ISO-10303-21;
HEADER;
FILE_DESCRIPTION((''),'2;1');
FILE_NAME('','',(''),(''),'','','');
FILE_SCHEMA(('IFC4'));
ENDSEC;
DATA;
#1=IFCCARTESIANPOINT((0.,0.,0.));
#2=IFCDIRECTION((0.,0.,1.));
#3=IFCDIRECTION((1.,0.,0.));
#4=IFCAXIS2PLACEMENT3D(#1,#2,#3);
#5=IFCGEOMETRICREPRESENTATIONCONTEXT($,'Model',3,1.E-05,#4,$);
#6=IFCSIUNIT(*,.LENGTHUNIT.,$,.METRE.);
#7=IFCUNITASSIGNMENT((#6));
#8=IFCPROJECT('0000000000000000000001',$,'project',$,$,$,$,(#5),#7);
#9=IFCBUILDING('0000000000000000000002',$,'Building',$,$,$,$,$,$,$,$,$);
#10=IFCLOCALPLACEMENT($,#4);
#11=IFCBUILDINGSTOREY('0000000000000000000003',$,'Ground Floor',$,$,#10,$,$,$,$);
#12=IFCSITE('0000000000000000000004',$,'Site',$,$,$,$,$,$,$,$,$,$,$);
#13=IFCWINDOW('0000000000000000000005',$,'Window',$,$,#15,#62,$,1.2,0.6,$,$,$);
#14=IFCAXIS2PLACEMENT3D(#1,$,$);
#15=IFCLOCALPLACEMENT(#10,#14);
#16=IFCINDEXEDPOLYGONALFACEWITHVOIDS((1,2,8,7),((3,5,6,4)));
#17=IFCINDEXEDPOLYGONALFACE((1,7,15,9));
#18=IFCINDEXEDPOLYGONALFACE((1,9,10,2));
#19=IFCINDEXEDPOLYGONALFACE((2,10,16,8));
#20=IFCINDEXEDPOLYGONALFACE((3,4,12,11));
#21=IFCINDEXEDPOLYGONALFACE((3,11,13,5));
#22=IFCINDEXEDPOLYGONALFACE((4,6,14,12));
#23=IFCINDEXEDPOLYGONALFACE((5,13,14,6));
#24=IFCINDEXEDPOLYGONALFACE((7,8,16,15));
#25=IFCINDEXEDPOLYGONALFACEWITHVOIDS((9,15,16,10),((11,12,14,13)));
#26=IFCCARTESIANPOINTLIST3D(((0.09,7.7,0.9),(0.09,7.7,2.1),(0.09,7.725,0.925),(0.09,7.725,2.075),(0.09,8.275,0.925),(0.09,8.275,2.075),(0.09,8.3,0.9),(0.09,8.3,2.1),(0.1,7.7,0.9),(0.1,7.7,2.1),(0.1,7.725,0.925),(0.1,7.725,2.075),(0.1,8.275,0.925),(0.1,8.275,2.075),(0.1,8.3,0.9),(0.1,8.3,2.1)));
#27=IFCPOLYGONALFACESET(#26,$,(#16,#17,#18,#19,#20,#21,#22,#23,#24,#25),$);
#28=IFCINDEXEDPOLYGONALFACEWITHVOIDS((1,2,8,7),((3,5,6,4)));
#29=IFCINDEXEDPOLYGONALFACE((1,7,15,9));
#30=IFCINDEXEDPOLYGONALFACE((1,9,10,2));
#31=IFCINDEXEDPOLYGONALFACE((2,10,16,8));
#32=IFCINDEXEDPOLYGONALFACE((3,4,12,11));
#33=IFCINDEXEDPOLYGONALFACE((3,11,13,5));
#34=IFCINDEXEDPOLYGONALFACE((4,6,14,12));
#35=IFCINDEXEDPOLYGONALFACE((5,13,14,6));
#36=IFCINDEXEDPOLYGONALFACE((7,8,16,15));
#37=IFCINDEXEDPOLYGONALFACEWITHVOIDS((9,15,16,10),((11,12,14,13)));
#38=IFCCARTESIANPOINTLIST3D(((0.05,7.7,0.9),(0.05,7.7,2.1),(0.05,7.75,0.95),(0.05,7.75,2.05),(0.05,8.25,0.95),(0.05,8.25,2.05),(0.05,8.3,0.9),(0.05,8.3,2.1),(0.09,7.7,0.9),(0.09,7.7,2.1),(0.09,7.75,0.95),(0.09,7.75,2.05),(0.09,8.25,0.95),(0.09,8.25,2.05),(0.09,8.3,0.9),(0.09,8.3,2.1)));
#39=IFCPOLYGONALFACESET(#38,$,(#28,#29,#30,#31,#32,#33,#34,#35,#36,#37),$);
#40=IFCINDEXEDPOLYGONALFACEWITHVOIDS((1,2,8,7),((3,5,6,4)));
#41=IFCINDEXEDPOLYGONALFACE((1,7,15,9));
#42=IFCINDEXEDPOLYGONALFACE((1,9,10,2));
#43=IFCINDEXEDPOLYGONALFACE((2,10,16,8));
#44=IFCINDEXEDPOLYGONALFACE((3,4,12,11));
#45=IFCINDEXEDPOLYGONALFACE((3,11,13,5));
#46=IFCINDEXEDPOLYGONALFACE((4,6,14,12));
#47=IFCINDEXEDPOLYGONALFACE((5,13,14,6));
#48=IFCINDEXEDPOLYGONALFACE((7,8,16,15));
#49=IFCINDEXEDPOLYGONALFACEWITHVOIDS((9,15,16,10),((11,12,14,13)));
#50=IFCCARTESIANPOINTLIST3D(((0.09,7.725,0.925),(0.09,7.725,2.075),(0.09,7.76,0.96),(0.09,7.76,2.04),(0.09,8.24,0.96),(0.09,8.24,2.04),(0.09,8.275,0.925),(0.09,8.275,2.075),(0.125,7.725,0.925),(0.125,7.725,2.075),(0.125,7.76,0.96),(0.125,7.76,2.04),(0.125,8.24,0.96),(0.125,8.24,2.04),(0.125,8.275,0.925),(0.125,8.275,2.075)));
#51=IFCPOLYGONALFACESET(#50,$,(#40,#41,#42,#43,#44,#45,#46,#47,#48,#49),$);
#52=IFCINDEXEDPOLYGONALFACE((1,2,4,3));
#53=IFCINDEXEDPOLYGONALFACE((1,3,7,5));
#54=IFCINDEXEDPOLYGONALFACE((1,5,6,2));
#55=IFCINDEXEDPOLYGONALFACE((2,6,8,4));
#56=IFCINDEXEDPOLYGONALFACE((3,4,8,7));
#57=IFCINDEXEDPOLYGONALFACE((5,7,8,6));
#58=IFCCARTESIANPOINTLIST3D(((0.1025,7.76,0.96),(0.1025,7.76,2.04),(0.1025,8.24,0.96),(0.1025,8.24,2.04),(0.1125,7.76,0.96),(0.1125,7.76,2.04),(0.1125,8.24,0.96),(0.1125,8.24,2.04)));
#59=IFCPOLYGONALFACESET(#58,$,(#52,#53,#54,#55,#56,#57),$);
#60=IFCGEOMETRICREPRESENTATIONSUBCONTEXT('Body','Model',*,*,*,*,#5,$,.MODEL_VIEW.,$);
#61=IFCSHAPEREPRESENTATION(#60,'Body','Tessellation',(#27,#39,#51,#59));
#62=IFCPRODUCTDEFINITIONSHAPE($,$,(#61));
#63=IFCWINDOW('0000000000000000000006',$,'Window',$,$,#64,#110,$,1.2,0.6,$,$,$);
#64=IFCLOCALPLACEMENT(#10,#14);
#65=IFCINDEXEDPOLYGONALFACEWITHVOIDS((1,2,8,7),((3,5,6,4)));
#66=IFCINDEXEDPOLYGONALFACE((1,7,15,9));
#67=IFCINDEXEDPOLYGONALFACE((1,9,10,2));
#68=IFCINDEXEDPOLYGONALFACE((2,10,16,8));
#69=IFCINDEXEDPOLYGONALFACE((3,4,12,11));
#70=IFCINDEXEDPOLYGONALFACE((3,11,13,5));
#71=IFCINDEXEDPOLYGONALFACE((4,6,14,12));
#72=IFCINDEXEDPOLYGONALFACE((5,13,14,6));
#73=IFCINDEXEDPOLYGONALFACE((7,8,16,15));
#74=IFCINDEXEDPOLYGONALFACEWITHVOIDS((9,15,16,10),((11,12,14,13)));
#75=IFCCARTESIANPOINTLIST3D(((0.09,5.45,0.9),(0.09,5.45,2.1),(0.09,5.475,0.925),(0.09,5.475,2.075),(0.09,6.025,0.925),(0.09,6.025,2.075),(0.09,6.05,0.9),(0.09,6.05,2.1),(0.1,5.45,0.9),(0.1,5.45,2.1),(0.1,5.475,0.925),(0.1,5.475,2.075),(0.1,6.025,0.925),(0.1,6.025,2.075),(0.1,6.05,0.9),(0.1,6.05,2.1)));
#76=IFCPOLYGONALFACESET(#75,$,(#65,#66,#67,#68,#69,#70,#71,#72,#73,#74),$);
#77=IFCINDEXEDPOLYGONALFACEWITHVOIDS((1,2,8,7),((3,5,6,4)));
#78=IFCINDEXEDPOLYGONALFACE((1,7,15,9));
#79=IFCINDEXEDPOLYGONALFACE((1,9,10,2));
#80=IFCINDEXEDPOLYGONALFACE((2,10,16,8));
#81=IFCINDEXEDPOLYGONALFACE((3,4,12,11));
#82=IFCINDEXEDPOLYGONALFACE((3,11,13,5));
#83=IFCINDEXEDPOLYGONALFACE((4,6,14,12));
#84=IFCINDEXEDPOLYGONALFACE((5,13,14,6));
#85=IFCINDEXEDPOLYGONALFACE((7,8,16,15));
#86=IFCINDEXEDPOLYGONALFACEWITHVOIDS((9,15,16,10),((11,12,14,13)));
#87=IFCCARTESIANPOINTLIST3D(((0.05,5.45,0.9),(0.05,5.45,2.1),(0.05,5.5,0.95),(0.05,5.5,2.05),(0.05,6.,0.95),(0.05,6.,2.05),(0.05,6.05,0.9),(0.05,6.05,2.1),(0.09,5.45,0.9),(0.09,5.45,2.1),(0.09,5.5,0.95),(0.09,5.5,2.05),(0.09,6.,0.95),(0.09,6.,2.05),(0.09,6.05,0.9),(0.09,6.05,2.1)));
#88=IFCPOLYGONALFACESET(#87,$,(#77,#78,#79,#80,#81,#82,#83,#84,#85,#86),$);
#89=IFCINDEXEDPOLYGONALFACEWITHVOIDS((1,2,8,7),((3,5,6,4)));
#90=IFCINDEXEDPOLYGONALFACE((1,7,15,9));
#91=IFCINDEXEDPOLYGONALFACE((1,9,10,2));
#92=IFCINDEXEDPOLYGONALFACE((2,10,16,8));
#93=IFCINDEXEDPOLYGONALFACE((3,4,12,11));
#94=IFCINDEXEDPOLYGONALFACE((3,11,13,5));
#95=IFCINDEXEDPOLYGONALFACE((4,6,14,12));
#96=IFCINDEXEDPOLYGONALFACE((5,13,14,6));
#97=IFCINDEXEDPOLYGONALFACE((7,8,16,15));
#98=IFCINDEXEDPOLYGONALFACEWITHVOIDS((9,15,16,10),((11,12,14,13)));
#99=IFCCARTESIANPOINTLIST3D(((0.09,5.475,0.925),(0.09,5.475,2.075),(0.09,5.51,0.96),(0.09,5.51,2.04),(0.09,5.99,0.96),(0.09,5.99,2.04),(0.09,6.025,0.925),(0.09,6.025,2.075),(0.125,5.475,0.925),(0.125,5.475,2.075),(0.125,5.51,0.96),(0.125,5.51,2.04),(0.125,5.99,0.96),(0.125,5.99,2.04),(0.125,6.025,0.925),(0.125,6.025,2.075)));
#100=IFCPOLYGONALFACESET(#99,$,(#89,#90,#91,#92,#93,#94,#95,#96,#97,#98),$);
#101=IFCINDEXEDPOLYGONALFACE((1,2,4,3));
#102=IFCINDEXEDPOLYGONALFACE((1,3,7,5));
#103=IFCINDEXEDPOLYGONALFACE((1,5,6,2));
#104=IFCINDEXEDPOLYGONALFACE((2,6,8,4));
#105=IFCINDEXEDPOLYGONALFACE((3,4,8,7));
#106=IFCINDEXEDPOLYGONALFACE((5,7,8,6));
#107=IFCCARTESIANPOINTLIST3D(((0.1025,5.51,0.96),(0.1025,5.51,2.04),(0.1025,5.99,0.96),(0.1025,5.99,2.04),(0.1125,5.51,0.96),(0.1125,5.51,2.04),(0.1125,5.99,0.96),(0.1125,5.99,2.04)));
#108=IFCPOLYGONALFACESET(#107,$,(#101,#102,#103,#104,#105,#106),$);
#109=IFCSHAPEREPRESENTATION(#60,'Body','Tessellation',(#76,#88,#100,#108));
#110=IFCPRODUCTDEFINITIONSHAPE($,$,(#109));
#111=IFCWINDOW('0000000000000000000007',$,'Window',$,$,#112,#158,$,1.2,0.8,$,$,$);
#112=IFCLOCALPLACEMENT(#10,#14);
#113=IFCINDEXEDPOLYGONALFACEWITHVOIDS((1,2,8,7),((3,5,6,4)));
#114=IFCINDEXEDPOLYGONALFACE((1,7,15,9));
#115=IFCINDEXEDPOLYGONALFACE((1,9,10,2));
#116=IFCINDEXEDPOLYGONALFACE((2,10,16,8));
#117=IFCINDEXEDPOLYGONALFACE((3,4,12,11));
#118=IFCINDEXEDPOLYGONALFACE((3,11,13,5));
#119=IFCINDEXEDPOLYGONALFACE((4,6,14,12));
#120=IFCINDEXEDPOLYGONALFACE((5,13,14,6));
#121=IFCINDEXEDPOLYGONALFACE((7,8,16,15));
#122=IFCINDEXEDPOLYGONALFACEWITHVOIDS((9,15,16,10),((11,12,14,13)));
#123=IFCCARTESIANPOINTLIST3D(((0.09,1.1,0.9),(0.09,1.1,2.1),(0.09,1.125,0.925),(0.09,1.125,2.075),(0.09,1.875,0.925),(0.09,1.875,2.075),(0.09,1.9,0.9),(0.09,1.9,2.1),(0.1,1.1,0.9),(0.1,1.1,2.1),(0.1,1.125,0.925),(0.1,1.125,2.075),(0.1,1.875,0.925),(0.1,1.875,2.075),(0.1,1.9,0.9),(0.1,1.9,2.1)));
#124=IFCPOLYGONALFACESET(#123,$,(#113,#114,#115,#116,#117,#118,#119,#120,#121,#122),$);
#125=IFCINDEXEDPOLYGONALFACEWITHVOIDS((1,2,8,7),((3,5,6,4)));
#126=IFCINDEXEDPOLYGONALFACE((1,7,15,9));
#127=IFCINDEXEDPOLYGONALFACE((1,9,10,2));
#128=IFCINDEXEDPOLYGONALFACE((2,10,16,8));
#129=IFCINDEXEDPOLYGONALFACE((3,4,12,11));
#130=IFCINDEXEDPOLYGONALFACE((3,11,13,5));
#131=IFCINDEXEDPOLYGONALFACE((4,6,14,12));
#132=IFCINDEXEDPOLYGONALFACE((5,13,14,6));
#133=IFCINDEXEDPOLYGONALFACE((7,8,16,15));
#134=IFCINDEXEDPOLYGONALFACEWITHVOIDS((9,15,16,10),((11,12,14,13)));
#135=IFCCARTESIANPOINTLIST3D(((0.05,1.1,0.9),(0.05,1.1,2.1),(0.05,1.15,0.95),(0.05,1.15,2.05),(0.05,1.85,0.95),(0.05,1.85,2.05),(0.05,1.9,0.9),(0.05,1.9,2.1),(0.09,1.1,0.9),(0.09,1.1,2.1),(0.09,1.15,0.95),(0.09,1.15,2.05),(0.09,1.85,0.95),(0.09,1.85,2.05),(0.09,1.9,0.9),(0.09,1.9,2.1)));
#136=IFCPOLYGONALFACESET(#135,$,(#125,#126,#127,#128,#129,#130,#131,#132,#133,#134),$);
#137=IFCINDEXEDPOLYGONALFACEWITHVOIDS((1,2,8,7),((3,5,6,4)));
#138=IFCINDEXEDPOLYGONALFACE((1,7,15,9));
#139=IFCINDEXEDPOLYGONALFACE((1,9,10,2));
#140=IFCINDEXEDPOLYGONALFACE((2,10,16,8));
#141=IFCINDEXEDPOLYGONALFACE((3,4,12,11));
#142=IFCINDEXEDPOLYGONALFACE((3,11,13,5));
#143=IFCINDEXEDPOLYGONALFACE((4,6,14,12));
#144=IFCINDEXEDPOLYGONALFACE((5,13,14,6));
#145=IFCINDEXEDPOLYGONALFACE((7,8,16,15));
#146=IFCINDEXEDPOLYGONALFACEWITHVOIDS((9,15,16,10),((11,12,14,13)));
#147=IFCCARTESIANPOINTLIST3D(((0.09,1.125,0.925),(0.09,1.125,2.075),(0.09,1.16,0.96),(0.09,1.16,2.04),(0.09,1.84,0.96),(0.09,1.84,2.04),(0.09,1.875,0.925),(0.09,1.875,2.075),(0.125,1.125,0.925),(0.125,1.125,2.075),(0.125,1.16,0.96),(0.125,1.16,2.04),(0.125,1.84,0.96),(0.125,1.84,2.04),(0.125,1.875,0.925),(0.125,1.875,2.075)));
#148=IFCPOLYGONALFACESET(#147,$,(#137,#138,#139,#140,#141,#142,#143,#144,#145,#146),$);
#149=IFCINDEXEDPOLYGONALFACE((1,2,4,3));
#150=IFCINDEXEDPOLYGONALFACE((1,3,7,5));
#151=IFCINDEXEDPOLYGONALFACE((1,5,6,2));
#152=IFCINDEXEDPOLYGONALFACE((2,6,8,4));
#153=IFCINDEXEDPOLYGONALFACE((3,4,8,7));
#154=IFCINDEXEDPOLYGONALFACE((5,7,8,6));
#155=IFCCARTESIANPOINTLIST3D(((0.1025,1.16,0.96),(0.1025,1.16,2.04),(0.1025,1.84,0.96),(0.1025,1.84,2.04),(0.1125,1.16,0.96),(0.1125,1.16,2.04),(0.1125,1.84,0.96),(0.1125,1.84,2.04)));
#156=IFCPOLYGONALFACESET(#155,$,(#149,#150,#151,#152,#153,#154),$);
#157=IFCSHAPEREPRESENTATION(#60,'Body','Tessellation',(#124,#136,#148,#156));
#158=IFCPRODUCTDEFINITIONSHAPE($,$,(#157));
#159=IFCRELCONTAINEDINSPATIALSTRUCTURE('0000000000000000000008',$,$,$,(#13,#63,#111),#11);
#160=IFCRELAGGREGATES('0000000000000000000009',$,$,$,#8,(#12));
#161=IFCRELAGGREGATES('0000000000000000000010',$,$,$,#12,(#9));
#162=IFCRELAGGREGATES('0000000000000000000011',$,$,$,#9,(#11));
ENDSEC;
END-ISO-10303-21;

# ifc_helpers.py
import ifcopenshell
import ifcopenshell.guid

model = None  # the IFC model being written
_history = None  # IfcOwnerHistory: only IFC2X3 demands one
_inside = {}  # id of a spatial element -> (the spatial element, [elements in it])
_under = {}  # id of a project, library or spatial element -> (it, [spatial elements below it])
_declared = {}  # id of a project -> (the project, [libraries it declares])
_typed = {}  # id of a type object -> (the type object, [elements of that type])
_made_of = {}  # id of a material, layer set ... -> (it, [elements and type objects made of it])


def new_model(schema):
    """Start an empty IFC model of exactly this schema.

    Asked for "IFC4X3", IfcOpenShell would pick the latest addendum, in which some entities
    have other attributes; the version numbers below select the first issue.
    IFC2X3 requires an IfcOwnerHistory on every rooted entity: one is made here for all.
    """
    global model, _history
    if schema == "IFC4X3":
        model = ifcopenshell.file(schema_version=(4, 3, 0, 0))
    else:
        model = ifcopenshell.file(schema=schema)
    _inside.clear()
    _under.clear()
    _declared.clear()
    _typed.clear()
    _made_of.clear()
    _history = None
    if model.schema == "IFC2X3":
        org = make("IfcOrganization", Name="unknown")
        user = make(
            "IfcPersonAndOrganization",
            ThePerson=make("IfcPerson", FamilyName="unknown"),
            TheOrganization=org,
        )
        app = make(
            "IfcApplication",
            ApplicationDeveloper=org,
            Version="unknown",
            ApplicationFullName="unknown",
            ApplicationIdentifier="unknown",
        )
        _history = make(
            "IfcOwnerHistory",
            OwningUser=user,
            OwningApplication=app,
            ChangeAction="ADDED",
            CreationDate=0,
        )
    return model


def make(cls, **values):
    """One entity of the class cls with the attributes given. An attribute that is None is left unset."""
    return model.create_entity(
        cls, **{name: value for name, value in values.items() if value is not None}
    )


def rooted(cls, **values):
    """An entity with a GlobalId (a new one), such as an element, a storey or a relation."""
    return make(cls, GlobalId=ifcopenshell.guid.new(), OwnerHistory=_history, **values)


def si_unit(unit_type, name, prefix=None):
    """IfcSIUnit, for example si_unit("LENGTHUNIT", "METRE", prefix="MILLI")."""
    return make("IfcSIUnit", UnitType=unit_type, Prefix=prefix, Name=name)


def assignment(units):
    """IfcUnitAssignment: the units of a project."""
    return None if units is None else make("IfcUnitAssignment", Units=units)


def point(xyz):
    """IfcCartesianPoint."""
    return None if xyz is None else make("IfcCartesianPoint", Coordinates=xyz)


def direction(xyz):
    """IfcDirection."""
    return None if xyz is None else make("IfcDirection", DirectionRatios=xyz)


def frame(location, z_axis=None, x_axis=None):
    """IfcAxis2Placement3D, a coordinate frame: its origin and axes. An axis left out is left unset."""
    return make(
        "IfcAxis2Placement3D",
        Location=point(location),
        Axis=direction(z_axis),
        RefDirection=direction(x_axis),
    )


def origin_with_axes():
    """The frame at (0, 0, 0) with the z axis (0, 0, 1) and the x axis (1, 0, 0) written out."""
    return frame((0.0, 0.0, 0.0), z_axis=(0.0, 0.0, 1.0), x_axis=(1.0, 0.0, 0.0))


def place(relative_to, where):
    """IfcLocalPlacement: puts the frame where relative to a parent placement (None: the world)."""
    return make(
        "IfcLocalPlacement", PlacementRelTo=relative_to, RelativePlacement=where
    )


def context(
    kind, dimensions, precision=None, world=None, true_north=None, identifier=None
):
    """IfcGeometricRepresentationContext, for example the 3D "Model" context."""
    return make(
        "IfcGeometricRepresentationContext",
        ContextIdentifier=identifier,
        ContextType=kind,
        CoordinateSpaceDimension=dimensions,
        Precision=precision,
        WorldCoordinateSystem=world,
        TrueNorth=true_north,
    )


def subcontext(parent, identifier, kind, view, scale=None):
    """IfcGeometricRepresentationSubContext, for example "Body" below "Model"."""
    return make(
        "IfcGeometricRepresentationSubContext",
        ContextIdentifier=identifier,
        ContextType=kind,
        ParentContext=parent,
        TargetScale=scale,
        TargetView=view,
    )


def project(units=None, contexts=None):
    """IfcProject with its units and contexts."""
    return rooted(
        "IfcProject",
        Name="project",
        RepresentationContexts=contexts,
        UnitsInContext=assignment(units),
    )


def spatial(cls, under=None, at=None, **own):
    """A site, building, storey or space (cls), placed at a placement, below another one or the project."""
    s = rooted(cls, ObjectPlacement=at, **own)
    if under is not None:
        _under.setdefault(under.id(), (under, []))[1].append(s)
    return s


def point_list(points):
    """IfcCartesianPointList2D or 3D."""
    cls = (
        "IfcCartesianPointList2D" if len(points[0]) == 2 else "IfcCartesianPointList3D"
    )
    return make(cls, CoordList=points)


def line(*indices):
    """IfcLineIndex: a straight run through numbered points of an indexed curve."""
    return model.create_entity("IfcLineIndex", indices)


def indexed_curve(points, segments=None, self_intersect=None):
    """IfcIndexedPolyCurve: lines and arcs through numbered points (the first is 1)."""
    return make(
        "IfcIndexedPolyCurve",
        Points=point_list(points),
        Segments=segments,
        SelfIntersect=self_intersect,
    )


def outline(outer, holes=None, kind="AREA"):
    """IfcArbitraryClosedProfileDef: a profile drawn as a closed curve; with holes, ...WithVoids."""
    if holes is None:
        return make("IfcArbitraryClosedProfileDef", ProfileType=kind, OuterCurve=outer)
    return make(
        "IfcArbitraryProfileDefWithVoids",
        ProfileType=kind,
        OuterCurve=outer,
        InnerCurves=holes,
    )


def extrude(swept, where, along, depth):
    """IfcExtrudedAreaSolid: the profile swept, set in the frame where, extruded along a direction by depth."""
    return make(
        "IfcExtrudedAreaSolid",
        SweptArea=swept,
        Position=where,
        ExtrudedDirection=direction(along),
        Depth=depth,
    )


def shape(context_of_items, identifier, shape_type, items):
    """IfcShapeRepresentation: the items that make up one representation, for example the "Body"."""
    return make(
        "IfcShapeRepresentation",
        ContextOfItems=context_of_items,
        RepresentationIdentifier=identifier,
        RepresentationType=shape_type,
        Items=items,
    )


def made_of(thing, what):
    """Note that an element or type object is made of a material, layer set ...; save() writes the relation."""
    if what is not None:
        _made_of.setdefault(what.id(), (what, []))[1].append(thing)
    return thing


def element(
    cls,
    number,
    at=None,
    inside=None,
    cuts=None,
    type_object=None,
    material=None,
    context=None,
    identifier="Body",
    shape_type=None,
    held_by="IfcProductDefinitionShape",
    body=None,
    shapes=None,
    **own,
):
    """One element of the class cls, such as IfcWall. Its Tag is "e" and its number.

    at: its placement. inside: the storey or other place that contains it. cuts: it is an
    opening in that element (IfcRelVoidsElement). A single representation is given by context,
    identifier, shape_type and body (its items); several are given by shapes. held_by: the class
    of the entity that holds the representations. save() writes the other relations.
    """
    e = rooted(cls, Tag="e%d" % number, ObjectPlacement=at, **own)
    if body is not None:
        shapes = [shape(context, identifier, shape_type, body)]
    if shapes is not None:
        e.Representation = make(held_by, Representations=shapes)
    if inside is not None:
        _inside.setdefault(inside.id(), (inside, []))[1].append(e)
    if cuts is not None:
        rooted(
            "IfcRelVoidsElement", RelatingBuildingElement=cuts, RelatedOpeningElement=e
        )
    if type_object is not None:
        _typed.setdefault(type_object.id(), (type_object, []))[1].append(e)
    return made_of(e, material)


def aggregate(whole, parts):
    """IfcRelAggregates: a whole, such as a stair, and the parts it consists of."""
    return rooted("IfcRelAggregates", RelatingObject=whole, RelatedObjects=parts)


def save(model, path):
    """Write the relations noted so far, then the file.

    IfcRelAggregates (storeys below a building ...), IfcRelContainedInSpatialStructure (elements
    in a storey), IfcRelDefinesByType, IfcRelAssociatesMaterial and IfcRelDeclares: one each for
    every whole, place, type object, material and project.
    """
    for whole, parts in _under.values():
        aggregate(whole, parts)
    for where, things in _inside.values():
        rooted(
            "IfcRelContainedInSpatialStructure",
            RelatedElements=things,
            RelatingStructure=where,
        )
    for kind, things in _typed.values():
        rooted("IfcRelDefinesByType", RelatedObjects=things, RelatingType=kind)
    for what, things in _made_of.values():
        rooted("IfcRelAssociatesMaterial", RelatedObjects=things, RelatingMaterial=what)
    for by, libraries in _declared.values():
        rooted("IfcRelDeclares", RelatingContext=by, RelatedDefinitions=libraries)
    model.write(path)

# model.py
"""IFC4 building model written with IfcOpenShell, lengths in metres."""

from ifc_helpers import new_model, si_unit, frame, origin_with_axes, place, context, subcontext, project, spatial, line, indexed_curve, outline, extrude, element, save


model = new_model("IFC4")

# Units and contexts
model_context = context("Model", 3, precision=1e-05, world=origin_with_axes())
body_context = subcontext(model_context, "Body", "Model", "MODEL_VIEW")
ifc_project = project(units=[si_unit("LENGTHUNIT", "METRE")], contexts=[model_context])

# Site, building, storey
site = spatial("IfcSite", under=ifc_project, Name="Site")
building = spatial("IfcBuilding", under=site, Name="Building")
storey_placement = place(None, origin_with_axes())
storey = spatial("IfcBuildingStorey", under=building, at=storey_placement, Name="Ground Floor")

# Windows
for number, where, z_axis, x_axis, name in (
    (1, (0.0, 8.3, 0.9), (0.0, 0.0, 1.0), (0.0, -1.0, 0.0), "Window"),
    (2, (0.0, 6.05, 0.9), (0.0, 0.0, 1.0), (0.0, -1.0, 0.0), "Window"),
):
    element("IfcWindow", number, at=place(storey_placement, frame(where, z_axis=z_axis, x_axis=x_axis)), inside=storey, Name=name, OverallHeight=1.2, OverallWidth=0.6, context=body_context, shape_type="SweptSolid", body=[
        extrude(outline(indexed_curve([(0.0, 0.0), (0.6, 0.0), (0.6, 1.2), (0.0, 1.2)], segments=[line(1, 2, 3, 4, 1)]), holes=[indexed_curve([(0.025, 0.025), (0.575, 0.025), (0.575, 1.175), (0.025, 1.175)], segments=[line(1, 2, 3, 4, 1)])]), frame((0.0, 0.09, 0.0), z_axis=(0.0, -1.0, 0.0), x_axis=(1.0, 0.0, 0.0)), (0.0, 0.0, -1.0), 0.01),
        extrude(outline(indexed_curve([(0.0, 0.0), (0.6, 0.0), (0.6, 1.2), (0.0, 1.2)], segments=[line(1, 2, 3, 4, 1)]), holes=[indexed_curve([(0.05, 0.05), (0.55, 0.05), (0.55, 1.15), (0.05, 1.15)], segments=[line(1, 2, 3, 4, 1)])]), frame((0.0, 0.05, 0.0), z_axis=(0.0, -1.0, 0.0), x_axis=(1.0, 0.0, 0.0)), (0.0, 0.0, -1.0), 0.04),
        extrude(outline(indexed_curve([(0.0, 0.0), (0.55, 0.0), (0.55, 1.15), (0.0, 1.15)], segments=[line(1, 2, 3, 4, 1)]), holes=[indexed_curve([(0.035, 0.035), (0.515, 0.035), (0.515, 1.115), (0.035, 1.115)], segments=[line(1, 2, 3, 4, 1)])]), frame((0.025, 0.09, 0.025), z_axis=(0.0, -1.0, 0.0), x_axis=(1.0, 0.0, 0.0)), (0.0, 0.0, -1.0), 0.035),
        extrude(outline(indexed_curve([(0.035, 0.035), (0.515, 0.035), (0.515, 1.115), (0.035, 1.115)], segments=[line(1, 2, 3, 4, 1)])), frame((0.025, 0.1025, 0.025), z_axis=(0.0, -1.0, 0.0), x_axis=(1.0, 0.0, 0.0)), (0.0, 0.0, -1.0), 0.01),
    ])
window_1_placement = place(storey_placement, frame((0.0, 1.9, 0.9), z_axis=(0.0, 0.0, 1.0), x_axis=(0.0, -1.0, 0.0)))
element("IfcWindow", 3, at=window_1_placement, inside=storey, Name="Window", OverallHeight=1.2, OverallWidth=0.8, context=body_context, shape_type="SweptSolid", body=[
    extrude(outline(indexed_curve([(0.0, 0.0), (0.8, 0.0), (0.8, 1.2), (0.0, 1.2)], segments=[line(1, 2, 3, 4, 1)]), holes=[indexed_curve([(0.025, 0.025), (0.775, 0.025), (0.775, 1.175), (0.025, 1.175)], segments=[line(1, 2, 3, 4, 1)])]), frame((0.0, 0.09, 0.0), z_axis=(0.0, -1.0, 0.0), x_axis=(1.0, 0.0, 0.0)), (0.0, 0.0, -1.0), 0.01),
    extrude(outline(indexed_curve([(0.0, 0.0), (0.8, 0.0), (0.8, 1.2), (0.0, 1.2)], segments=[line(1, 2, 3, 4, 1)]), holes=[indexed_curve([(0.05, 0.05), (0.75, 0.05), (0.75, 1.15), (0.05, 1.15)], segments=[line(1, 2, 3, 4, 1)])]), frame((0.0, 0.05, 0.0), z_axis=(0.0, -1.0, 0.0), x_axis=(1.0, 0.0, 0.0)), (0.0, 0.0, -1.0), 0.04),
    extrude(outline(indexed_curve([(0.0, 0.0), (0.75, 0.0), (0.75, 1.15), (0.0, 1.15)], segments=[line(1, 2, 3, 4, 1)]), holes=[indexed_curve([(0.035, 0.035), (0.715, 0.035), (0.715, 1.115), (0.035, 1.115)], segments=[line(1, 2, 3, 4, 1)])]), frame((0.025, 0.09, 0.025), z_axis=(0.0, -1.0, 0.0), x_axis=(1.0, 0.0, 0.0)), (0.0, 0.0, -1.0), 0.035),
    extrude(outline(indexed_curve([(0.035, 0.035), (0.715, 0.035), (0.715, 1.115), (0.035, 1.115)], segments=[line(1, 2, 3, 4, 1)])), frame((0.025, 0.1025, 0.025), z_axis=(0.0, -1.0, 0.0), x_axis=(1.0, 0.0, 0.0)), (0.0, 0.0, -1.0), 0.01),
])

save(model, "model.ifc")
